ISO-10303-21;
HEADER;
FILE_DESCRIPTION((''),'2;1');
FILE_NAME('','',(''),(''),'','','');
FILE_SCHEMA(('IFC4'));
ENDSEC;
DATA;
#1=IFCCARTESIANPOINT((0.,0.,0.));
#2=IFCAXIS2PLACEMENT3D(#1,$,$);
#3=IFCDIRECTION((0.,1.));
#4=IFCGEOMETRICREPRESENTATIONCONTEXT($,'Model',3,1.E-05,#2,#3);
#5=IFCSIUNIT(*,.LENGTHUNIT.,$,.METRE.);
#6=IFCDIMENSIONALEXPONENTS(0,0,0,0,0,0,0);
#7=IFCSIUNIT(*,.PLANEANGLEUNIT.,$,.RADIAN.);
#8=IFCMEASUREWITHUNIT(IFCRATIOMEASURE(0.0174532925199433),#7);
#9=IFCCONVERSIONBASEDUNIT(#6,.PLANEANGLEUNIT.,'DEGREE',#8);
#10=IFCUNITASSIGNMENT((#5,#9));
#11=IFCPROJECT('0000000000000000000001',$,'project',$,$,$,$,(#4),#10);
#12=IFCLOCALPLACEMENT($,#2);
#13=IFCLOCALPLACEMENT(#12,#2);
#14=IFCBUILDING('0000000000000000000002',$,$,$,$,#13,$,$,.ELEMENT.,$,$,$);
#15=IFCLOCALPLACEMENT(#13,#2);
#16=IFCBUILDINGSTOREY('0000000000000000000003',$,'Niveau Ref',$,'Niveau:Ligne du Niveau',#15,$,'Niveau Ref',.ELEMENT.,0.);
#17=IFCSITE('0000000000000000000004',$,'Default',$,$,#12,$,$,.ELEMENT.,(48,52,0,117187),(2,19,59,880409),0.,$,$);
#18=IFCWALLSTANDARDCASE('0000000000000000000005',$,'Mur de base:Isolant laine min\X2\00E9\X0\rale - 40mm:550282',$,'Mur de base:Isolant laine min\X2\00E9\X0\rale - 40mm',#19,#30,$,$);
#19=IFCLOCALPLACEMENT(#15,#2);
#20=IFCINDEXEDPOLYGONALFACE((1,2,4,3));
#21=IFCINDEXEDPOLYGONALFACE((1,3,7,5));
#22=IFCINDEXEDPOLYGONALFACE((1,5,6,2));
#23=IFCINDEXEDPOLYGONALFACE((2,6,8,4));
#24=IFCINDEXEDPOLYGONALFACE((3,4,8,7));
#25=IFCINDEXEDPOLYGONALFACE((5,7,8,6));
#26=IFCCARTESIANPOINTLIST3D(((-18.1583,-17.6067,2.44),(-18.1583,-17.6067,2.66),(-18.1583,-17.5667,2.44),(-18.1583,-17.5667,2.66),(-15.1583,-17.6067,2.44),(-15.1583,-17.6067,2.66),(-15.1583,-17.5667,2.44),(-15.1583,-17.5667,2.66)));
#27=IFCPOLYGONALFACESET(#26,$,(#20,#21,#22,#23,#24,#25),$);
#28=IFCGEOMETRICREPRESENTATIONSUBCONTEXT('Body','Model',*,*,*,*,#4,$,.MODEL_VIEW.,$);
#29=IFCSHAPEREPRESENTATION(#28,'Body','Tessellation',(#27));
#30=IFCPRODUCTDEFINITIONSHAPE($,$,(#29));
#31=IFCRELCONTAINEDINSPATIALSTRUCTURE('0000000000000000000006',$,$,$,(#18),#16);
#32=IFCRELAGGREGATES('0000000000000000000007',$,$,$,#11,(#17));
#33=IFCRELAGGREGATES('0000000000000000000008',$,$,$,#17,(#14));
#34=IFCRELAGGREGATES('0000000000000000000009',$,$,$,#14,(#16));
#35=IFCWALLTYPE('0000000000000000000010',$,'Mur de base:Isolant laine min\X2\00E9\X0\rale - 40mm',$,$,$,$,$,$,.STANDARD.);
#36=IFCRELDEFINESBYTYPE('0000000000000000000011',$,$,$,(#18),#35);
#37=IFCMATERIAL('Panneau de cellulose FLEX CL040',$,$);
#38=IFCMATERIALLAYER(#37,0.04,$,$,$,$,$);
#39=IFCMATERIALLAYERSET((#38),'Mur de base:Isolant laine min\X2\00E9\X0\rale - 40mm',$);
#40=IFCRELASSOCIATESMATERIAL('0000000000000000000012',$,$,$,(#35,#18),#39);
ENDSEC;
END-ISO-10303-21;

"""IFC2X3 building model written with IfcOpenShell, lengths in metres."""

from ifc_helpers import new_model, entity, si_unit, converted_unit, direction, frame, frame_2d, origin, place, context, subcontext, project, spatial, rectangle, extrude, material, layer, layer_set, layer_usage, type_object, element, save


model = new_model("IFC2X3")

# Units and contexts
model_context = context("Model", 3, precision=1e-05, world=origin(), true_north=direction((0.0, 1.0)))
body_context = subcontext(model_context, "Body", "Model", "MODEL_VIEW")
ifc_project = project(units=[si_unit("LENGTHUNIT", "METRE"), converted_unit("PLANEANGLEUNIT", "DEGREE", entity("IfcRatioMeasure", 0.0174532925199433), si_unit("PLANEANGLEUNIT", "RADIAN"), dimensions=[0, 0, 0, 0, 0, 0, 0])], contexts=[model_context])

# Site, building, storey
site_placement = place(None, origin())
site = spatial("IfcSite", under=ifc_project, at=site_placement, Name="Default", CompositionType="ELEMENT", RefLatitude=(48, 52, 0, 117187), RefLongitude=(2, 19, 59, 880409), RefElevation=0.0)
building_placement = place(site_placement, origin())
building = spatial("IfcBuilding", under=site, at=building_placement, CompositionType="ELEMENT")
storey_placement = place(building_placement, origin())
storey = spatial("IfcBuildingStorey", under=building, at=storey_placement, Name="Niveau Ref", ObjectType="Niveau:Ligne du Niveau", LongName="Niveau Ref", CompositionType="ELEMENT", Elevation=0.0)

# Wall
ifc_material_1 = material(Name="Panneau de cellulose FLEX CL040")
ifc_layer = layer(ifc_material_1, 0.04)
ifc_layer_set = layer_set([ifc_layer], Name="Mur de base:Isolant laine minérale - 40mm")
wall_type = type_object("IfcWallType", Name="Mur de base:Isolant laine minérale - 40mm", PredefinedType="STANDARD", material=ifc_layer_set)
ifc_layer_usage_1 = layer_usage(ifc_layer_set, "AXIS2", "NEGATIVE", 0.02)
wall_1_placement = place(storey_placement, frame((-18.1583, -17.5867, 2.44)))
element("IfcWallStandardCase", 1, at=wall_1_placement, inside=storey, type_object=wall_type, material=ifc_layer_usage_1, Name="Mur de base:Isolant laine minérale - 40mm:550282", ObjectType="Mur de base:Isolant laine minérale - 40mm", context=body_context, shape_type="SweptSolid", body=[
    extrude(rectangle(XDim=3.0, YDim=0.04, at=frame_2d((1.5, 0.0), x_axis=(-1.0, 0.0))), origin(), (0.0, 0.0, 1.0), 0.22),
])

save(model, "model.ifc")
